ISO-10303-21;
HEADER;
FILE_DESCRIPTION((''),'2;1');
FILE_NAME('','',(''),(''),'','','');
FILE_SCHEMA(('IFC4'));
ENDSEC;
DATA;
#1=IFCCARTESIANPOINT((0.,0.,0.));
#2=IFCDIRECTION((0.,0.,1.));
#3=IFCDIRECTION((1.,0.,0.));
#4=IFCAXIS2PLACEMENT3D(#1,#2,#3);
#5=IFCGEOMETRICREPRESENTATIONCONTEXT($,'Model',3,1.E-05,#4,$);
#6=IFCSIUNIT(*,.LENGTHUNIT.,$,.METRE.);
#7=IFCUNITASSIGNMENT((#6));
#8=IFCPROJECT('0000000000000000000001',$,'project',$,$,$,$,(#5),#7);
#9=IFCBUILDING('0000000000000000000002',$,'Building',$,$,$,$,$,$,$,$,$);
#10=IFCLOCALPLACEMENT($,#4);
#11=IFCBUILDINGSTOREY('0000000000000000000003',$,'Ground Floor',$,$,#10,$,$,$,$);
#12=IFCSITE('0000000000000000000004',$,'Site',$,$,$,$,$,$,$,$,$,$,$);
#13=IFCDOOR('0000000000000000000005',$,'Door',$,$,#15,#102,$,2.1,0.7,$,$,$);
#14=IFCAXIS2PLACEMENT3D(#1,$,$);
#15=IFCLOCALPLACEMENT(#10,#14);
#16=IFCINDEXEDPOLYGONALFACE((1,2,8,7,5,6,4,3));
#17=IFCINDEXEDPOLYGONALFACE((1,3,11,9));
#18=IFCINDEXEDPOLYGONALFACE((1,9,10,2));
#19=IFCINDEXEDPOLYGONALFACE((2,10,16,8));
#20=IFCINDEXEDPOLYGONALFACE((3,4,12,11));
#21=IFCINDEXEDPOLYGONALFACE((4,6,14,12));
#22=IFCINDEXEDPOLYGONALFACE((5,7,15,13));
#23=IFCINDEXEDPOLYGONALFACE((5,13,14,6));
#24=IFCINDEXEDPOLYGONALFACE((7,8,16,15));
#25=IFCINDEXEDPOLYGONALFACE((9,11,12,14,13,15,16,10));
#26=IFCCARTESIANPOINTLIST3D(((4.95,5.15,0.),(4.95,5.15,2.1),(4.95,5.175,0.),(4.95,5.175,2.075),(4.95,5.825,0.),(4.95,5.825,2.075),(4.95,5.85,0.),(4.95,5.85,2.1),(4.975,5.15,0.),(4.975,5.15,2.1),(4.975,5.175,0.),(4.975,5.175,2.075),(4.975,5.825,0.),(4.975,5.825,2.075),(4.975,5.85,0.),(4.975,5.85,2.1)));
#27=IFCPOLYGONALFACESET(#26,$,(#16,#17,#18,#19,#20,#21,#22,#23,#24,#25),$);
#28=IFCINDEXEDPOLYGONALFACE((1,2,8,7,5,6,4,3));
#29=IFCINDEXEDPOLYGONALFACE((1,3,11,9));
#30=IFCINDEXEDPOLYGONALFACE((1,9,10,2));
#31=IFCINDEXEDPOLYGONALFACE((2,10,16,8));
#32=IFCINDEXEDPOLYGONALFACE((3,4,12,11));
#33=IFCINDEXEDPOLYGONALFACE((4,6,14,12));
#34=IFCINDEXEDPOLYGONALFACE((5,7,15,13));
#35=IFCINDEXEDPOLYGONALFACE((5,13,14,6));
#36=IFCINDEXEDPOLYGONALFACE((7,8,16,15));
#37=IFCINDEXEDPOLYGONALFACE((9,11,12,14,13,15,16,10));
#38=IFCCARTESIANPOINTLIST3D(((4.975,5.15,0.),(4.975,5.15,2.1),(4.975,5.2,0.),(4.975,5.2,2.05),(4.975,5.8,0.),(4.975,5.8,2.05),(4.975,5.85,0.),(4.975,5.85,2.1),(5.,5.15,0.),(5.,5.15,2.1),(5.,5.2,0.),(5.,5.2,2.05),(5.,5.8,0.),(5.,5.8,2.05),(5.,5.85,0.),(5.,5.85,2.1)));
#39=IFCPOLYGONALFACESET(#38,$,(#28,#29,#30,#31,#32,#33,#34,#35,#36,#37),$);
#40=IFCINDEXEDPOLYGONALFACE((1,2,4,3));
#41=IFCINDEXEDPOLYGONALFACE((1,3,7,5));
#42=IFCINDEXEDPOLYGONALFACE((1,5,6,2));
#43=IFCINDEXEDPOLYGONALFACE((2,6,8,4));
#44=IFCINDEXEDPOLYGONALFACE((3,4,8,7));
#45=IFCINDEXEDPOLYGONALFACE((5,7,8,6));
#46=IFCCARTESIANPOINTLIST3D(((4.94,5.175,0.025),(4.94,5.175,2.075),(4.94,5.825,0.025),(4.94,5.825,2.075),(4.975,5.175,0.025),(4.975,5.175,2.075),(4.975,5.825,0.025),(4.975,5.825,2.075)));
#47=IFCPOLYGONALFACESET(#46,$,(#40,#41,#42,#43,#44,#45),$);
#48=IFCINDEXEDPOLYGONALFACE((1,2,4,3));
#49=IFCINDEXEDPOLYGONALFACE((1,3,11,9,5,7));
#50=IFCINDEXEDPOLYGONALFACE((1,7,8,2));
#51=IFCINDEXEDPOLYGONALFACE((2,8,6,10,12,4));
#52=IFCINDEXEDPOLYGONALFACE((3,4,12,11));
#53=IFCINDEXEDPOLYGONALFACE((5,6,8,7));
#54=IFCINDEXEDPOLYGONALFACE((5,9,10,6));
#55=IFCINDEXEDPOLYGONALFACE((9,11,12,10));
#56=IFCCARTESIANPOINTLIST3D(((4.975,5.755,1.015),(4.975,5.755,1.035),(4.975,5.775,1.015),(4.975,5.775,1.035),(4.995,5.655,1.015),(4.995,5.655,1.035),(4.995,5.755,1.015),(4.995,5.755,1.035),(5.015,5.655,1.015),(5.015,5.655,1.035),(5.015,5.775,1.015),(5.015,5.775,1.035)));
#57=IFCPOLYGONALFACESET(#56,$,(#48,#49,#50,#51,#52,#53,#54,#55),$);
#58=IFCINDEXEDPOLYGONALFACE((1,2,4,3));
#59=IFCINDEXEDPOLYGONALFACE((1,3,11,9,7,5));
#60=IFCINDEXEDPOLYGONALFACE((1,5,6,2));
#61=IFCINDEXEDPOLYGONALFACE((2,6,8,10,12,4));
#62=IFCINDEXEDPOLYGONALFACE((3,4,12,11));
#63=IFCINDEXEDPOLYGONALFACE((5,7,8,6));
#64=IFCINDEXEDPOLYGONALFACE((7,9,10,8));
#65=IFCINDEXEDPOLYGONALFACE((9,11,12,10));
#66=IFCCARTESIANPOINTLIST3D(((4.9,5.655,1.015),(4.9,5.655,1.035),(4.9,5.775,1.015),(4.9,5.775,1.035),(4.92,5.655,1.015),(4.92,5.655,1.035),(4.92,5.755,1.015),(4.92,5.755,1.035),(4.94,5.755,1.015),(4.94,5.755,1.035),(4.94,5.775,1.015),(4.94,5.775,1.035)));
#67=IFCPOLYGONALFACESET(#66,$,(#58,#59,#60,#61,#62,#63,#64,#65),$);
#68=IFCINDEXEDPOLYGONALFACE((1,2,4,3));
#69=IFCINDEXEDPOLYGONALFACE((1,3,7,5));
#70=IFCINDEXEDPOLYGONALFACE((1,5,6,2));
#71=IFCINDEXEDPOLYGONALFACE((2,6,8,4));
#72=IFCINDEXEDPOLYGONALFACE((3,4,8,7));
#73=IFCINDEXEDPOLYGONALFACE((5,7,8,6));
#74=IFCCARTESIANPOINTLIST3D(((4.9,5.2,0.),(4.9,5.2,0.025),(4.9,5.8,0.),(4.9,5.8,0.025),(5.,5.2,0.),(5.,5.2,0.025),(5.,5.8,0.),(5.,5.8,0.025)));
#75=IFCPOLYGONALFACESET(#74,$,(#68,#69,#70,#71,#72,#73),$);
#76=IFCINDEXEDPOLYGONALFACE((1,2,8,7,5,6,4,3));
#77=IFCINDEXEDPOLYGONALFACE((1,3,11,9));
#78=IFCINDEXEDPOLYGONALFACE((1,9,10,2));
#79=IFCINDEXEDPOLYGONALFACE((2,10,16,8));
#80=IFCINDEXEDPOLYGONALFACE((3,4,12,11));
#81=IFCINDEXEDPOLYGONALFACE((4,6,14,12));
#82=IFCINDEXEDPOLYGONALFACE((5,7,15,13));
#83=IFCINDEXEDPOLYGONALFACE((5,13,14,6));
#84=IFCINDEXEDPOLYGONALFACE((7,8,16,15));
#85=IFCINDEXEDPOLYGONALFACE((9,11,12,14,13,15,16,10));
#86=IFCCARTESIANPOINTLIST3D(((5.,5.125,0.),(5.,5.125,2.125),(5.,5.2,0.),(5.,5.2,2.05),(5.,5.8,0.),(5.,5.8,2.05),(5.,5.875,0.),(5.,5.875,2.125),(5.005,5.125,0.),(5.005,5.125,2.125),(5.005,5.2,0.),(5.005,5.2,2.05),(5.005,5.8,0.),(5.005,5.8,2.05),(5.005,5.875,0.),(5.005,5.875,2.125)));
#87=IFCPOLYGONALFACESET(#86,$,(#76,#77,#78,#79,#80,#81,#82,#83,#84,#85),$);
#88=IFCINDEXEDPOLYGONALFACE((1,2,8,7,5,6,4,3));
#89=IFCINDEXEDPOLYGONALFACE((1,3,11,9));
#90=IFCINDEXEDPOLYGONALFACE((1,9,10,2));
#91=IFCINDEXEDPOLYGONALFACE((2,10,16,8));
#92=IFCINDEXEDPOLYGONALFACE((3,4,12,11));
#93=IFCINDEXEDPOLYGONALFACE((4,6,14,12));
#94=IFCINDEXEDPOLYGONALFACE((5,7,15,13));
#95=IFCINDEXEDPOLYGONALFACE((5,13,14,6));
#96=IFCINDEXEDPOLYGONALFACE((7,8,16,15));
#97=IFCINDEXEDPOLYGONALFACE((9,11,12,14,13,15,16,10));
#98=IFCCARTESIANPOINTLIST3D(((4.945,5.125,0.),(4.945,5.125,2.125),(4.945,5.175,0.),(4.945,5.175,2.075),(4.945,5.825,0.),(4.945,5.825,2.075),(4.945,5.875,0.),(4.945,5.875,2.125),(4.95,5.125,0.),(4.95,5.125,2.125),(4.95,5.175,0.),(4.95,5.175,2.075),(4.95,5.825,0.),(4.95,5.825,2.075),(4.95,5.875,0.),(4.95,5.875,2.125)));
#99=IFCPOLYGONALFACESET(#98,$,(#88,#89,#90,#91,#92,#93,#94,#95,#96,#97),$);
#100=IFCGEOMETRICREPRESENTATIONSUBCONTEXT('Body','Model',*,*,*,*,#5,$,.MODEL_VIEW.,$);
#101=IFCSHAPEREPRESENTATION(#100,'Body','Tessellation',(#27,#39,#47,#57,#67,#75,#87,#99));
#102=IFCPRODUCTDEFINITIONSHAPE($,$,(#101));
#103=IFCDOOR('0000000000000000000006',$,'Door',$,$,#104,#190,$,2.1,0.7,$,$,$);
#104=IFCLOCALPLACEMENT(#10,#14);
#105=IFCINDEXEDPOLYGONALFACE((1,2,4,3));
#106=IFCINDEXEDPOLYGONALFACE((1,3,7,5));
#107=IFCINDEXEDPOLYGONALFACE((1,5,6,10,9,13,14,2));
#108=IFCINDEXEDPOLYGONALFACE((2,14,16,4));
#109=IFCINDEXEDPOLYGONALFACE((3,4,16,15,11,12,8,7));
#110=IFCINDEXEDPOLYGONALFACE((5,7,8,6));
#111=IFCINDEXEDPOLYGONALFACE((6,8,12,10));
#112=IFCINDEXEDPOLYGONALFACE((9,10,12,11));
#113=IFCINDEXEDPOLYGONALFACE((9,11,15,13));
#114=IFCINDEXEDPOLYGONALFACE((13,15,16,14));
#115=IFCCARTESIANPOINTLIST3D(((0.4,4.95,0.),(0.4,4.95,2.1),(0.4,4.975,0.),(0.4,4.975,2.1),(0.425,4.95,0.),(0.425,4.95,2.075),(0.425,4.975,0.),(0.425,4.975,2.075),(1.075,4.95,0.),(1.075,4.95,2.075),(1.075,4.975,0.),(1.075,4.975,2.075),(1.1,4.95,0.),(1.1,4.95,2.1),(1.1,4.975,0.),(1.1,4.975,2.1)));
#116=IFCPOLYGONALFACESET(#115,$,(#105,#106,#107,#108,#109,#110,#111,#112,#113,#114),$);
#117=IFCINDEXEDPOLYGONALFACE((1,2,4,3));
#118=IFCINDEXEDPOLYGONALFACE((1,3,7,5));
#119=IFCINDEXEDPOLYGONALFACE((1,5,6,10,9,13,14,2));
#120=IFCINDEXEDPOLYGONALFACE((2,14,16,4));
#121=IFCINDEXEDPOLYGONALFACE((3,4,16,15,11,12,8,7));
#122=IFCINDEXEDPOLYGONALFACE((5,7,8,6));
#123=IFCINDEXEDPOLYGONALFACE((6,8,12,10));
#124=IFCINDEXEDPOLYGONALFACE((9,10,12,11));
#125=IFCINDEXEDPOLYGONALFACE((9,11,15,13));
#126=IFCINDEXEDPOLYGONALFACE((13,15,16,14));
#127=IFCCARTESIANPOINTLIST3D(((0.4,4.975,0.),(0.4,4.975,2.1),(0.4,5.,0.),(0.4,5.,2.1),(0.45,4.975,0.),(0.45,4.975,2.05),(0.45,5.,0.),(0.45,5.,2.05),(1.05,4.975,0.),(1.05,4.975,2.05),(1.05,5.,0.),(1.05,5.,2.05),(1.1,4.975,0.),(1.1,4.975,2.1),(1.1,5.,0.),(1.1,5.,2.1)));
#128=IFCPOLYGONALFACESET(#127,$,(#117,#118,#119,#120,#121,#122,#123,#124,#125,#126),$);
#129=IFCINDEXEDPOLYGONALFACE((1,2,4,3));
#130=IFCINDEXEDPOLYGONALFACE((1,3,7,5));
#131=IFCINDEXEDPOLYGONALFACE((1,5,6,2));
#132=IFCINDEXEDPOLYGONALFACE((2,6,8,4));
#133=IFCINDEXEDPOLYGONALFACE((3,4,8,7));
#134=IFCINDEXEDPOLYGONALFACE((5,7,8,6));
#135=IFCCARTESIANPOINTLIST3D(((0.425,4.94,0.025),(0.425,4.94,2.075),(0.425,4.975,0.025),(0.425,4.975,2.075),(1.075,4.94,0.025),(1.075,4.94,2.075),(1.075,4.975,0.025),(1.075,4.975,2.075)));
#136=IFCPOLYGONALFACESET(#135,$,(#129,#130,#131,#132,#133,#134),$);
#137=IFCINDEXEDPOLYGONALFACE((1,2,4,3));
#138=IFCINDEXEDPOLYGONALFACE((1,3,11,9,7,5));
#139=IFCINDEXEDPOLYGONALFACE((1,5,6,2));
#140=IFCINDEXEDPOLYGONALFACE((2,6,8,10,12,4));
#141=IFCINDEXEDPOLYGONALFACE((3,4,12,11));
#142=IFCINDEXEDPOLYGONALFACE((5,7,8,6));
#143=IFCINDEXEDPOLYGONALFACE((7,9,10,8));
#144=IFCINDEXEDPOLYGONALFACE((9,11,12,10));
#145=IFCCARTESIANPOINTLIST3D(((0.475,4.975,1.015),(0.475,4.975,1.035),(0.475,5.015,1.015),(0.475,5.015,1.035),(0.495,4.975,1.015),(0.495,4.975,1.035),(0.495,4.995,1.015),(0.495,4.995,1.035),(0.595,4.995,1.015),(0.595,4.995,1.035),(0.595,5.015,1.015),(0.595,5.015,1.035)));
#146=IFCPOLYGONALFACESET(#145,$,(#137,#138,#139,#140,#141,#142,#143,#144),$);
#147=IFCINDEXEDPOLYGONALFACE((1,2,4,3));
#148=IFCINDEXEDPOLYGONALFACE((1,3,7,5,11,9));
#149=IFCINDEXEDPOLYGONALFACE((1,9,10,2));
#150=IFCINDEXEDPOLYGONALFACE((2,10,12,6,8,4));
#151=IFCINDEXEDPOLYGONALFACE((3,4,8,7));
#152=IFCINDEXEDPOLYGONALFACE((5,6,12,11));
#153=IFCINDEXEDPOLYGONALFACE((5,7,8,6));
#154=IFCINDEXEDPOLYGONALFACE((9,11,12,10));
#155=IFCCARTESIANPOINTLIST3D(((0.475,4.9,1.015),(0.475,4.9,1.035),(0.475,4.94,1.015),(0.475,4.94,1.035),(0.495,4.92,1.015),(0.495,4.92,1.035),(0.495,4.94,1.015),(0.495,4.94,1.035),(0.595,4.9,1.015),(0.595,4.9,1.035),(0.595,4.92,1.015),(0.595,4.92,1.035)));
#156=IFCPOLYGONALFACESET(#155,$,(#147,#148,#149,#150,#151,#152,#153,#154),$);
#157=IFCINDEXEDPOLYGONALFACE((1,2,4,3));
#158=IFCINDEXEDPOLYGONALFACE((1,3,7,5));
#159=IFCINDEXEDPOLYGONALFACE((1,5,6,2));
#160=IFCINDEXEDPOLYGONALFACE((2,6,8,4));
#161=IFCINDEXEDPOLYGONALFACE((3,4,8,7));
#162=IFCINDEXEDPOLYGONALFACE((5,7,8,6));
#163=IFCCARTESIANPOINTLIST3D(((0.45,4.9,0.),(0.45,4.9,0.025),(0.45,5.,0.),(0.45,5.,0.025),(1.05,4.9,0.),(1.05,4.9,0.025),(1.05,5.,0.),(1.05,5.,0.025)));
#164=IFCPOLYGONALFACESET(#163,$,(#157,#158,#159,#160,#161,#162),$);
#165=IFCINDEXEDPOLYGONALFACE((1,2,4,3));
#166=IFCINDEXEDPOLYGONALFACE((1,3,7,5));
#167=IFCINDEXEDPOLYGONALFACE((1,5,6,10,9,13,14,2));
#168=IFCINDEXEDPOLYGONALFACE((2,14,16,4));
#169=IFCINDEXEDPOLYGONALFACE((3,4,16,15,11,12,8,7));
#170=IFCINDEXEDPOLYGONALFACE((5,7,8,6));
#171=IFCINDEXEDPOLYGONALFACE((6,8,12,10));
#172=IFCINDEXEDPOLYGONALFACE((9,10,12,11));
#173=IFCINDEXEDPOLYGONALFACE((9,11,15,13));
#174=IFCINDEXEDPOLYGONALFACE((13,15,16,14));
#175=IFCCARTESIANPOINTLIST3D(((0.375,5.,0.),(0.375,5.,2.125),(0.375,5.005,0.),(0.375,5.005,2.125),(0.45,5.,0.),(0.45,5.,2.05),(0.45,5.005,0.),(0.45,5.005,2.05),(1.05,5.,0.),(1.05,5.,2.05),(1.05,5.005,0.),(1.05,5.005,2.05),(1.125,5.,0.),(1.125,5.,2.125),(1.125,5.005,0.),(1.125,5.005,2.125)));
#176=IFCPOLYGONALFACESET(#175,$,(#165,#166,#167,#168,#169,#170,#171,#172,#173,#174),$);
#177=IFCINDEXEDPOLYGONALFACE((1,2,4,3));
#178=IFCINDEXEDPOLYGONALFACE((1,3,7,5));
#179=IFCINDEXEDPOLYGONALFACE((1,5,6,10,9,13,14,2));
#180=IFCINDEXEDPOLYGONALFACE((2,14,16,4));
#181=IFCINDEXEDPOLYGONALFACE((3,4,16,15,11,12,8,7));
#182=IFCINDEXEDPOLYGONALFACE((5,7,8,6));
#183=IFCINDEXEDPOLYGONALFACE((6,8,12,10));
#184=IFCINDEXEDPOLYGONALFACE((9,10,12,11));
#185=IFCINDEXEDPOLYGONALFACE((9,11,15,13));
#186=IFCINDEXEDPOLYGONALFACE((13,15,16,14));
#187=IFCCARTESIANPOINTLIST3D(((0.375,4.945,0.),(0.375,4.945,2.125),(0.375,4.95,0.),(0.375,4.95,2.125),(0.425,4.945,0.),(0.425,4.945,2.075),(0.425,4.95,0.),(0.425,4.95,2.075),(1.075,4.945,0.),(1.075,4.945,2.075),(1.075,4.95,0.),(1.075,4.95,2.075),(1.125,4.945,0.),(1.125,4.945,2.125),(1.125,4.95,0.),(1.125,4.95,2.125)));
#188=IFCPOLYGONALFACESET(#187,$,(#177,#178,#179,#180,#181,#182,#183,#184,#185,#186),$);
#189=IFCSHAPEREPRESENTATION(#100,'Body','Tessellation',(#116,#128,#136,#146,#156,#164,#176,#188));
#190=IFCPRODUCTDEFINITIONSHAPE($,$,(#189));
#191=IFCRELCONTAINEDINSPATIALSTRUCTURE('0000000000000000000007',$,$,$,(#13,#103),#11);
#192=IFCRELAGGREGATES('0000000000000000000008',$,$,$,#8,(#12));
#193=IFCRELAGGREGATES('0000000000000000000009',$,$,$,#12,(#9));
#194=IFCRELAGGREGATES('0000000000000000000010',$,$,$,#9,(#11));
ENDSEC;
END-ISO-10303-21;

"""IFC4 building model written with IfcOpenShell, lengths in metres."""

from ifc_helpers import new_model, si_unit, frame, origin_with_axes, place, context, subcontext, project, spatial, line, indexed_curve, outline, extrude, element, save


model = new_model("IFC4")

# Units and contexts
model_context = context("Model", 3, precision=1e-05, world=origin_with_axes())
body_context = subcontext(model_context, "Body", "Model", "MODEL_VIEW")
ifc_project = project(units=[si_unit("LENGTHUNIT", "METRE")], contexts=[model_context])

# Site, building, storey
site = spatial("IfcSite", under=ifc_project, Name="Site")
building = spatial("IfcBuilding", under=site, Name="Building")
storey_placement = place(None, origin_with_axes())
storey = spatial("IfcBuildingStorey", under=building, at=storey_placement, Name="Ground Floor")

# Doors
door_1_placement = place(storey_placement, frame((5.0, 5.15, 0.0), z_axis=(0.0, 0.0, 1.0), x_axis=(0.0, 1.0, 0.0)))
element("IfcDoor", 1, at=door_1_placement, inside=storey, Name="Door", OverallHeight=2.1, OverallWidth=0.7, context=body_context, shape_type="SweptSolid", body=[
    extrude(outline(indexed_curve([(0.0, 0.0), (0.0, 2.1), (0.7, 2.1), (0.7, 0.0), (0.675, 0.0), (0.675, 2.075), (0.025, 2.075), (0.025, 0.0)], segments=[line(1, 2, 3, 4, 5, 6, 7, 8, 1)])), frame((0.0, 0.025, 0.0), z_axis=(0.0, -1.0, 0.0), x_axis=(1.0, 0.0, 0.0)), (0.0, 0.0, -1.0), 0.025),
    extrude(outline(indexed_curve([(0.0, 0.0), (0.0, 2.1), (0.7, 2.1), (0.7, 0.0), (0.65, 0.0), (0.65, 2.05), (0.05, 2.05), (0.05, 0.0)], segments=[line(1, 2, 3, 4, 5, 6, 7, 8, 1)])), frame((0.0, 0.0, 0.0), z_axis=(0.0, -1.0, 0.0), x_axis=(1.0, 0.0, 0.0)), (0.0, 0.0, -1.0), 0.025),
    extrude(outline(indexed_curve([(0.0, 0.0), (0.65, 0.0), (0.65, 0.035), (0.0, 0.035)], segments=[line(1, 2, 3, 4, 1)])), frame((0.025, 0.025, 0.025), z_axis=(0.0, 0.0, 1.0), x_axis=(1.0, 0.0, 0.0)), (0.0, 0.0, 1.0), 2.05),
    extrude(outline(indexed_curve([(0.0, 0.0), (0.0, -0.04), (-0.12, -0.04), (-0.12, -0.02), (-0.02, -0.02), (-0.02, 0.0)], segments=[line(1, 2, 3, 4, 5, 6, 1)])), frame((0.625, 0.025, 1.015), z_axis=(0.0, 0.0, 1.0), x_axis=(1.0, 0.0, 0.0)), (0.0, 0.0, 1.0), 0.02),
    extrude(outline(indexed_curve([(0.0, 0.0), (0.0, 0.04), (-0.12, 0.04), (-0.12, 0.02), (-0.02, 0.02), (-0.02, 0.0)], segments=[line(1, 2, 3, 4, 5, 6, 1)])), frame((0.625, 0.06, 1.015), z_axis=(0.0, 0.0, 1.0), x_axis=(1.0, 0.0, 0.0)), (0.0, 0.0, 1.0), 0.02),
    extrude(outline(indexed_curve([(0.0, 0.0), (0.6, 0.0), (0.6, 0.1), (0.0, 0.1)], segments=[line(1, 2, 3, 4, 1)])), frame((0.05, 0.0, 0.0), z_axis=(0.0, 0.0, 1.0), x_axis=(1.0, 0.0, 0.0)), (0.0, 0.0, 1.0), 0.025),
    extrude(outline(indexed_curve([(0.0, 0.0), (0.0, 2.125), (0.75, 2.125), (0.75, 0.0), (0.675, 0.0), (0.675, 2.05), (0.075, 2.05), (0.075, 0.0)], segments=[line(1, 2, 3, 4, 5, 6, 7, 8, 1)])), frame((-0.025, -0.005, 0.0), z_axis=(0.0, -1.0, 0.0), x_axis=(1.0, 0.0, 0.0)), (0.0, 0.0, -1.0), 0.005),
    extrude(outline(indexed_curve([(0.0, 0.0), (0.0, 2.125), (0.75, 2.125), (0.75, 0.0), (0.7, 0.0), (0.7, 2.075), (0.05, 2.075), (0.05, 0.0)], segments=[line(1, 2, 3, 4, 5, 6, 7, 8, 1)])), frame((-0.025, 0.05, 0.0), z_axis=(0.0, -1.0, 0.0), x_axis=(1.0, 0.0, 0.0)), (0.0, 0.0, -1.0), 0.005),
])
door_2_placement = place(storey_placement, frame((1.1, 5.0, 0.0), z_axis=(0.0, 0.0, 1.0), x_axis=(-1.0, 0.0, 0.0)))
element("IfcDoor", 2, at=door_2_placement, inside=storey, Name="Door", OverallHeight=2.1, OverallWidth=0.7, context=body_context, shape_type="SweptSolid", body=[
    extrude(outline(indexed_curve([(0.0, 0.0), (0.0, 2.1), (0.7, 2.1), (0.7, 0.0), (0.675, 0.0), (0.675, 2.075), (0.025, 2.075), (0.025, 0.0)], segments=[line(1, 2, 3, 4, 5, 6, 7, 8, 1)])), frame((0.0, 0.025, 0.0), z_axis=(0.0, -1.0, 0.0), x_axis=(1.0, 0.0, 0.0)), (0.0, 0.0, -1.0), 0.025),
    extrude(outline(indexed_curve([(0.0, 0.0), (0.0, 2.1), (0.7, 2.1), (0.7, 0.0), (0.65, 0.0), (0.65, 2.05), (0.05, 2.05), (0.05, 0.0)], segments=[line(1, 2, 3, 4, 5, 6, 7, 8, 1)])), frame((0.0, 0.0, 0.0), z_axis=(0.0, -1.0, 0.0), x_axis=(1.0, 0.0, 0.0)), (0.0, 0.0, -1.0), 0.025),
    extrude(outline(indexed_curve([(0.0, 0.0), (0.65, 0.0), (0.65, 0.035), (0.0, 0.035)], segments=[line(1, 2, 3, 4, 1)])), frame((0.025, 0.025, 0.025), z_axis=(0.0, 0.0, 1.0), x_axis=(1.0, 0.0, 0.0)), (0.0, 0.0, 1.0), 2.05),
    extrude(outline(indexed_curve([(0.0, 0.0), (0.0, -0.04), (-0.12, -0.04), (-0.12, -0.02), (-0.02, -0.02), (-0.02, 0.0)], segments=[line(1, 2, 3, 4, 5, 6, 1)])), frame((0.625, 0.025, 1.015), z_axis=(0.0, 0.0, 1.0), x_axis=(1.0, 0.0, 0.0)), (0.0, 0.0, 1.0), 0.02),
    extrude(outline(indexed_curve([(0.0, 0.0), (0.0, 0.04), (-0.12, 0.04), (-0.12, 0.02), (-0.02, 0.02), (-0.02, 0.0)], segments=[line(1, 2, 3, 4, 5, 6, 1)])), frame((0.625, 0.06, 1.015), z_axis=(0.0, 0.0, 1.0), x_axis=(1.0, 0.0, 0.0)), (0.0, 0.0, 1.0), 0.02),
    extrude(outline(indexed_curve([(0.0, 0.0), (0.6, 0.0), (0.6, 0.1), (0.0, 0.1)], segments=[line(1, 2, 3, 4, 1)])), frame((0.05, 0.0, 0.0), z_axis=(0.0, 0.0, 1.0), x_axis=(1.0, 0.0, 0.0)), (0.0, 0.0, 1.0), 0.025),
    extrude(outline(indexed_curve([(0.0, 0.0), (0.0, 2.125), (0.75, 2.125), (0.75, 0.0), (0.675, 0.0), (0.675, 2.05), (0.075, 2.05), (0.075, 0.0)], segments=[line(1, 2, 3, 4, 5, 6, 7, 8, 1)])), frame((-0.025, -0.005, 0.0), z_axis=(0.0, -1.0, 0.0), x_axis=(1.0, 0.0, 0.0)), (0.0, 0.0, -1.0), 0.005),
    extrude(outline(indexed_curve([(0.0, 0.0), (0.0, 2.125), (0.75, 2.125), (0.75, 0.0), (0.7, 0.0), (0.7, 2.075), (0.05, 2.075), (0.05, 0.0)], segments=[line(1, 2, 3, 4, 5, 6, 7, 8, 1)])), frame((-0.025, 0.05, 0.0), z_axis=(0.0, -1.0, 0.0), x_axis=(1.0, 0.0, 0.0)), (0.0, 0.0, -1.0), 0.005),
])

save(model, "model.ifc")
